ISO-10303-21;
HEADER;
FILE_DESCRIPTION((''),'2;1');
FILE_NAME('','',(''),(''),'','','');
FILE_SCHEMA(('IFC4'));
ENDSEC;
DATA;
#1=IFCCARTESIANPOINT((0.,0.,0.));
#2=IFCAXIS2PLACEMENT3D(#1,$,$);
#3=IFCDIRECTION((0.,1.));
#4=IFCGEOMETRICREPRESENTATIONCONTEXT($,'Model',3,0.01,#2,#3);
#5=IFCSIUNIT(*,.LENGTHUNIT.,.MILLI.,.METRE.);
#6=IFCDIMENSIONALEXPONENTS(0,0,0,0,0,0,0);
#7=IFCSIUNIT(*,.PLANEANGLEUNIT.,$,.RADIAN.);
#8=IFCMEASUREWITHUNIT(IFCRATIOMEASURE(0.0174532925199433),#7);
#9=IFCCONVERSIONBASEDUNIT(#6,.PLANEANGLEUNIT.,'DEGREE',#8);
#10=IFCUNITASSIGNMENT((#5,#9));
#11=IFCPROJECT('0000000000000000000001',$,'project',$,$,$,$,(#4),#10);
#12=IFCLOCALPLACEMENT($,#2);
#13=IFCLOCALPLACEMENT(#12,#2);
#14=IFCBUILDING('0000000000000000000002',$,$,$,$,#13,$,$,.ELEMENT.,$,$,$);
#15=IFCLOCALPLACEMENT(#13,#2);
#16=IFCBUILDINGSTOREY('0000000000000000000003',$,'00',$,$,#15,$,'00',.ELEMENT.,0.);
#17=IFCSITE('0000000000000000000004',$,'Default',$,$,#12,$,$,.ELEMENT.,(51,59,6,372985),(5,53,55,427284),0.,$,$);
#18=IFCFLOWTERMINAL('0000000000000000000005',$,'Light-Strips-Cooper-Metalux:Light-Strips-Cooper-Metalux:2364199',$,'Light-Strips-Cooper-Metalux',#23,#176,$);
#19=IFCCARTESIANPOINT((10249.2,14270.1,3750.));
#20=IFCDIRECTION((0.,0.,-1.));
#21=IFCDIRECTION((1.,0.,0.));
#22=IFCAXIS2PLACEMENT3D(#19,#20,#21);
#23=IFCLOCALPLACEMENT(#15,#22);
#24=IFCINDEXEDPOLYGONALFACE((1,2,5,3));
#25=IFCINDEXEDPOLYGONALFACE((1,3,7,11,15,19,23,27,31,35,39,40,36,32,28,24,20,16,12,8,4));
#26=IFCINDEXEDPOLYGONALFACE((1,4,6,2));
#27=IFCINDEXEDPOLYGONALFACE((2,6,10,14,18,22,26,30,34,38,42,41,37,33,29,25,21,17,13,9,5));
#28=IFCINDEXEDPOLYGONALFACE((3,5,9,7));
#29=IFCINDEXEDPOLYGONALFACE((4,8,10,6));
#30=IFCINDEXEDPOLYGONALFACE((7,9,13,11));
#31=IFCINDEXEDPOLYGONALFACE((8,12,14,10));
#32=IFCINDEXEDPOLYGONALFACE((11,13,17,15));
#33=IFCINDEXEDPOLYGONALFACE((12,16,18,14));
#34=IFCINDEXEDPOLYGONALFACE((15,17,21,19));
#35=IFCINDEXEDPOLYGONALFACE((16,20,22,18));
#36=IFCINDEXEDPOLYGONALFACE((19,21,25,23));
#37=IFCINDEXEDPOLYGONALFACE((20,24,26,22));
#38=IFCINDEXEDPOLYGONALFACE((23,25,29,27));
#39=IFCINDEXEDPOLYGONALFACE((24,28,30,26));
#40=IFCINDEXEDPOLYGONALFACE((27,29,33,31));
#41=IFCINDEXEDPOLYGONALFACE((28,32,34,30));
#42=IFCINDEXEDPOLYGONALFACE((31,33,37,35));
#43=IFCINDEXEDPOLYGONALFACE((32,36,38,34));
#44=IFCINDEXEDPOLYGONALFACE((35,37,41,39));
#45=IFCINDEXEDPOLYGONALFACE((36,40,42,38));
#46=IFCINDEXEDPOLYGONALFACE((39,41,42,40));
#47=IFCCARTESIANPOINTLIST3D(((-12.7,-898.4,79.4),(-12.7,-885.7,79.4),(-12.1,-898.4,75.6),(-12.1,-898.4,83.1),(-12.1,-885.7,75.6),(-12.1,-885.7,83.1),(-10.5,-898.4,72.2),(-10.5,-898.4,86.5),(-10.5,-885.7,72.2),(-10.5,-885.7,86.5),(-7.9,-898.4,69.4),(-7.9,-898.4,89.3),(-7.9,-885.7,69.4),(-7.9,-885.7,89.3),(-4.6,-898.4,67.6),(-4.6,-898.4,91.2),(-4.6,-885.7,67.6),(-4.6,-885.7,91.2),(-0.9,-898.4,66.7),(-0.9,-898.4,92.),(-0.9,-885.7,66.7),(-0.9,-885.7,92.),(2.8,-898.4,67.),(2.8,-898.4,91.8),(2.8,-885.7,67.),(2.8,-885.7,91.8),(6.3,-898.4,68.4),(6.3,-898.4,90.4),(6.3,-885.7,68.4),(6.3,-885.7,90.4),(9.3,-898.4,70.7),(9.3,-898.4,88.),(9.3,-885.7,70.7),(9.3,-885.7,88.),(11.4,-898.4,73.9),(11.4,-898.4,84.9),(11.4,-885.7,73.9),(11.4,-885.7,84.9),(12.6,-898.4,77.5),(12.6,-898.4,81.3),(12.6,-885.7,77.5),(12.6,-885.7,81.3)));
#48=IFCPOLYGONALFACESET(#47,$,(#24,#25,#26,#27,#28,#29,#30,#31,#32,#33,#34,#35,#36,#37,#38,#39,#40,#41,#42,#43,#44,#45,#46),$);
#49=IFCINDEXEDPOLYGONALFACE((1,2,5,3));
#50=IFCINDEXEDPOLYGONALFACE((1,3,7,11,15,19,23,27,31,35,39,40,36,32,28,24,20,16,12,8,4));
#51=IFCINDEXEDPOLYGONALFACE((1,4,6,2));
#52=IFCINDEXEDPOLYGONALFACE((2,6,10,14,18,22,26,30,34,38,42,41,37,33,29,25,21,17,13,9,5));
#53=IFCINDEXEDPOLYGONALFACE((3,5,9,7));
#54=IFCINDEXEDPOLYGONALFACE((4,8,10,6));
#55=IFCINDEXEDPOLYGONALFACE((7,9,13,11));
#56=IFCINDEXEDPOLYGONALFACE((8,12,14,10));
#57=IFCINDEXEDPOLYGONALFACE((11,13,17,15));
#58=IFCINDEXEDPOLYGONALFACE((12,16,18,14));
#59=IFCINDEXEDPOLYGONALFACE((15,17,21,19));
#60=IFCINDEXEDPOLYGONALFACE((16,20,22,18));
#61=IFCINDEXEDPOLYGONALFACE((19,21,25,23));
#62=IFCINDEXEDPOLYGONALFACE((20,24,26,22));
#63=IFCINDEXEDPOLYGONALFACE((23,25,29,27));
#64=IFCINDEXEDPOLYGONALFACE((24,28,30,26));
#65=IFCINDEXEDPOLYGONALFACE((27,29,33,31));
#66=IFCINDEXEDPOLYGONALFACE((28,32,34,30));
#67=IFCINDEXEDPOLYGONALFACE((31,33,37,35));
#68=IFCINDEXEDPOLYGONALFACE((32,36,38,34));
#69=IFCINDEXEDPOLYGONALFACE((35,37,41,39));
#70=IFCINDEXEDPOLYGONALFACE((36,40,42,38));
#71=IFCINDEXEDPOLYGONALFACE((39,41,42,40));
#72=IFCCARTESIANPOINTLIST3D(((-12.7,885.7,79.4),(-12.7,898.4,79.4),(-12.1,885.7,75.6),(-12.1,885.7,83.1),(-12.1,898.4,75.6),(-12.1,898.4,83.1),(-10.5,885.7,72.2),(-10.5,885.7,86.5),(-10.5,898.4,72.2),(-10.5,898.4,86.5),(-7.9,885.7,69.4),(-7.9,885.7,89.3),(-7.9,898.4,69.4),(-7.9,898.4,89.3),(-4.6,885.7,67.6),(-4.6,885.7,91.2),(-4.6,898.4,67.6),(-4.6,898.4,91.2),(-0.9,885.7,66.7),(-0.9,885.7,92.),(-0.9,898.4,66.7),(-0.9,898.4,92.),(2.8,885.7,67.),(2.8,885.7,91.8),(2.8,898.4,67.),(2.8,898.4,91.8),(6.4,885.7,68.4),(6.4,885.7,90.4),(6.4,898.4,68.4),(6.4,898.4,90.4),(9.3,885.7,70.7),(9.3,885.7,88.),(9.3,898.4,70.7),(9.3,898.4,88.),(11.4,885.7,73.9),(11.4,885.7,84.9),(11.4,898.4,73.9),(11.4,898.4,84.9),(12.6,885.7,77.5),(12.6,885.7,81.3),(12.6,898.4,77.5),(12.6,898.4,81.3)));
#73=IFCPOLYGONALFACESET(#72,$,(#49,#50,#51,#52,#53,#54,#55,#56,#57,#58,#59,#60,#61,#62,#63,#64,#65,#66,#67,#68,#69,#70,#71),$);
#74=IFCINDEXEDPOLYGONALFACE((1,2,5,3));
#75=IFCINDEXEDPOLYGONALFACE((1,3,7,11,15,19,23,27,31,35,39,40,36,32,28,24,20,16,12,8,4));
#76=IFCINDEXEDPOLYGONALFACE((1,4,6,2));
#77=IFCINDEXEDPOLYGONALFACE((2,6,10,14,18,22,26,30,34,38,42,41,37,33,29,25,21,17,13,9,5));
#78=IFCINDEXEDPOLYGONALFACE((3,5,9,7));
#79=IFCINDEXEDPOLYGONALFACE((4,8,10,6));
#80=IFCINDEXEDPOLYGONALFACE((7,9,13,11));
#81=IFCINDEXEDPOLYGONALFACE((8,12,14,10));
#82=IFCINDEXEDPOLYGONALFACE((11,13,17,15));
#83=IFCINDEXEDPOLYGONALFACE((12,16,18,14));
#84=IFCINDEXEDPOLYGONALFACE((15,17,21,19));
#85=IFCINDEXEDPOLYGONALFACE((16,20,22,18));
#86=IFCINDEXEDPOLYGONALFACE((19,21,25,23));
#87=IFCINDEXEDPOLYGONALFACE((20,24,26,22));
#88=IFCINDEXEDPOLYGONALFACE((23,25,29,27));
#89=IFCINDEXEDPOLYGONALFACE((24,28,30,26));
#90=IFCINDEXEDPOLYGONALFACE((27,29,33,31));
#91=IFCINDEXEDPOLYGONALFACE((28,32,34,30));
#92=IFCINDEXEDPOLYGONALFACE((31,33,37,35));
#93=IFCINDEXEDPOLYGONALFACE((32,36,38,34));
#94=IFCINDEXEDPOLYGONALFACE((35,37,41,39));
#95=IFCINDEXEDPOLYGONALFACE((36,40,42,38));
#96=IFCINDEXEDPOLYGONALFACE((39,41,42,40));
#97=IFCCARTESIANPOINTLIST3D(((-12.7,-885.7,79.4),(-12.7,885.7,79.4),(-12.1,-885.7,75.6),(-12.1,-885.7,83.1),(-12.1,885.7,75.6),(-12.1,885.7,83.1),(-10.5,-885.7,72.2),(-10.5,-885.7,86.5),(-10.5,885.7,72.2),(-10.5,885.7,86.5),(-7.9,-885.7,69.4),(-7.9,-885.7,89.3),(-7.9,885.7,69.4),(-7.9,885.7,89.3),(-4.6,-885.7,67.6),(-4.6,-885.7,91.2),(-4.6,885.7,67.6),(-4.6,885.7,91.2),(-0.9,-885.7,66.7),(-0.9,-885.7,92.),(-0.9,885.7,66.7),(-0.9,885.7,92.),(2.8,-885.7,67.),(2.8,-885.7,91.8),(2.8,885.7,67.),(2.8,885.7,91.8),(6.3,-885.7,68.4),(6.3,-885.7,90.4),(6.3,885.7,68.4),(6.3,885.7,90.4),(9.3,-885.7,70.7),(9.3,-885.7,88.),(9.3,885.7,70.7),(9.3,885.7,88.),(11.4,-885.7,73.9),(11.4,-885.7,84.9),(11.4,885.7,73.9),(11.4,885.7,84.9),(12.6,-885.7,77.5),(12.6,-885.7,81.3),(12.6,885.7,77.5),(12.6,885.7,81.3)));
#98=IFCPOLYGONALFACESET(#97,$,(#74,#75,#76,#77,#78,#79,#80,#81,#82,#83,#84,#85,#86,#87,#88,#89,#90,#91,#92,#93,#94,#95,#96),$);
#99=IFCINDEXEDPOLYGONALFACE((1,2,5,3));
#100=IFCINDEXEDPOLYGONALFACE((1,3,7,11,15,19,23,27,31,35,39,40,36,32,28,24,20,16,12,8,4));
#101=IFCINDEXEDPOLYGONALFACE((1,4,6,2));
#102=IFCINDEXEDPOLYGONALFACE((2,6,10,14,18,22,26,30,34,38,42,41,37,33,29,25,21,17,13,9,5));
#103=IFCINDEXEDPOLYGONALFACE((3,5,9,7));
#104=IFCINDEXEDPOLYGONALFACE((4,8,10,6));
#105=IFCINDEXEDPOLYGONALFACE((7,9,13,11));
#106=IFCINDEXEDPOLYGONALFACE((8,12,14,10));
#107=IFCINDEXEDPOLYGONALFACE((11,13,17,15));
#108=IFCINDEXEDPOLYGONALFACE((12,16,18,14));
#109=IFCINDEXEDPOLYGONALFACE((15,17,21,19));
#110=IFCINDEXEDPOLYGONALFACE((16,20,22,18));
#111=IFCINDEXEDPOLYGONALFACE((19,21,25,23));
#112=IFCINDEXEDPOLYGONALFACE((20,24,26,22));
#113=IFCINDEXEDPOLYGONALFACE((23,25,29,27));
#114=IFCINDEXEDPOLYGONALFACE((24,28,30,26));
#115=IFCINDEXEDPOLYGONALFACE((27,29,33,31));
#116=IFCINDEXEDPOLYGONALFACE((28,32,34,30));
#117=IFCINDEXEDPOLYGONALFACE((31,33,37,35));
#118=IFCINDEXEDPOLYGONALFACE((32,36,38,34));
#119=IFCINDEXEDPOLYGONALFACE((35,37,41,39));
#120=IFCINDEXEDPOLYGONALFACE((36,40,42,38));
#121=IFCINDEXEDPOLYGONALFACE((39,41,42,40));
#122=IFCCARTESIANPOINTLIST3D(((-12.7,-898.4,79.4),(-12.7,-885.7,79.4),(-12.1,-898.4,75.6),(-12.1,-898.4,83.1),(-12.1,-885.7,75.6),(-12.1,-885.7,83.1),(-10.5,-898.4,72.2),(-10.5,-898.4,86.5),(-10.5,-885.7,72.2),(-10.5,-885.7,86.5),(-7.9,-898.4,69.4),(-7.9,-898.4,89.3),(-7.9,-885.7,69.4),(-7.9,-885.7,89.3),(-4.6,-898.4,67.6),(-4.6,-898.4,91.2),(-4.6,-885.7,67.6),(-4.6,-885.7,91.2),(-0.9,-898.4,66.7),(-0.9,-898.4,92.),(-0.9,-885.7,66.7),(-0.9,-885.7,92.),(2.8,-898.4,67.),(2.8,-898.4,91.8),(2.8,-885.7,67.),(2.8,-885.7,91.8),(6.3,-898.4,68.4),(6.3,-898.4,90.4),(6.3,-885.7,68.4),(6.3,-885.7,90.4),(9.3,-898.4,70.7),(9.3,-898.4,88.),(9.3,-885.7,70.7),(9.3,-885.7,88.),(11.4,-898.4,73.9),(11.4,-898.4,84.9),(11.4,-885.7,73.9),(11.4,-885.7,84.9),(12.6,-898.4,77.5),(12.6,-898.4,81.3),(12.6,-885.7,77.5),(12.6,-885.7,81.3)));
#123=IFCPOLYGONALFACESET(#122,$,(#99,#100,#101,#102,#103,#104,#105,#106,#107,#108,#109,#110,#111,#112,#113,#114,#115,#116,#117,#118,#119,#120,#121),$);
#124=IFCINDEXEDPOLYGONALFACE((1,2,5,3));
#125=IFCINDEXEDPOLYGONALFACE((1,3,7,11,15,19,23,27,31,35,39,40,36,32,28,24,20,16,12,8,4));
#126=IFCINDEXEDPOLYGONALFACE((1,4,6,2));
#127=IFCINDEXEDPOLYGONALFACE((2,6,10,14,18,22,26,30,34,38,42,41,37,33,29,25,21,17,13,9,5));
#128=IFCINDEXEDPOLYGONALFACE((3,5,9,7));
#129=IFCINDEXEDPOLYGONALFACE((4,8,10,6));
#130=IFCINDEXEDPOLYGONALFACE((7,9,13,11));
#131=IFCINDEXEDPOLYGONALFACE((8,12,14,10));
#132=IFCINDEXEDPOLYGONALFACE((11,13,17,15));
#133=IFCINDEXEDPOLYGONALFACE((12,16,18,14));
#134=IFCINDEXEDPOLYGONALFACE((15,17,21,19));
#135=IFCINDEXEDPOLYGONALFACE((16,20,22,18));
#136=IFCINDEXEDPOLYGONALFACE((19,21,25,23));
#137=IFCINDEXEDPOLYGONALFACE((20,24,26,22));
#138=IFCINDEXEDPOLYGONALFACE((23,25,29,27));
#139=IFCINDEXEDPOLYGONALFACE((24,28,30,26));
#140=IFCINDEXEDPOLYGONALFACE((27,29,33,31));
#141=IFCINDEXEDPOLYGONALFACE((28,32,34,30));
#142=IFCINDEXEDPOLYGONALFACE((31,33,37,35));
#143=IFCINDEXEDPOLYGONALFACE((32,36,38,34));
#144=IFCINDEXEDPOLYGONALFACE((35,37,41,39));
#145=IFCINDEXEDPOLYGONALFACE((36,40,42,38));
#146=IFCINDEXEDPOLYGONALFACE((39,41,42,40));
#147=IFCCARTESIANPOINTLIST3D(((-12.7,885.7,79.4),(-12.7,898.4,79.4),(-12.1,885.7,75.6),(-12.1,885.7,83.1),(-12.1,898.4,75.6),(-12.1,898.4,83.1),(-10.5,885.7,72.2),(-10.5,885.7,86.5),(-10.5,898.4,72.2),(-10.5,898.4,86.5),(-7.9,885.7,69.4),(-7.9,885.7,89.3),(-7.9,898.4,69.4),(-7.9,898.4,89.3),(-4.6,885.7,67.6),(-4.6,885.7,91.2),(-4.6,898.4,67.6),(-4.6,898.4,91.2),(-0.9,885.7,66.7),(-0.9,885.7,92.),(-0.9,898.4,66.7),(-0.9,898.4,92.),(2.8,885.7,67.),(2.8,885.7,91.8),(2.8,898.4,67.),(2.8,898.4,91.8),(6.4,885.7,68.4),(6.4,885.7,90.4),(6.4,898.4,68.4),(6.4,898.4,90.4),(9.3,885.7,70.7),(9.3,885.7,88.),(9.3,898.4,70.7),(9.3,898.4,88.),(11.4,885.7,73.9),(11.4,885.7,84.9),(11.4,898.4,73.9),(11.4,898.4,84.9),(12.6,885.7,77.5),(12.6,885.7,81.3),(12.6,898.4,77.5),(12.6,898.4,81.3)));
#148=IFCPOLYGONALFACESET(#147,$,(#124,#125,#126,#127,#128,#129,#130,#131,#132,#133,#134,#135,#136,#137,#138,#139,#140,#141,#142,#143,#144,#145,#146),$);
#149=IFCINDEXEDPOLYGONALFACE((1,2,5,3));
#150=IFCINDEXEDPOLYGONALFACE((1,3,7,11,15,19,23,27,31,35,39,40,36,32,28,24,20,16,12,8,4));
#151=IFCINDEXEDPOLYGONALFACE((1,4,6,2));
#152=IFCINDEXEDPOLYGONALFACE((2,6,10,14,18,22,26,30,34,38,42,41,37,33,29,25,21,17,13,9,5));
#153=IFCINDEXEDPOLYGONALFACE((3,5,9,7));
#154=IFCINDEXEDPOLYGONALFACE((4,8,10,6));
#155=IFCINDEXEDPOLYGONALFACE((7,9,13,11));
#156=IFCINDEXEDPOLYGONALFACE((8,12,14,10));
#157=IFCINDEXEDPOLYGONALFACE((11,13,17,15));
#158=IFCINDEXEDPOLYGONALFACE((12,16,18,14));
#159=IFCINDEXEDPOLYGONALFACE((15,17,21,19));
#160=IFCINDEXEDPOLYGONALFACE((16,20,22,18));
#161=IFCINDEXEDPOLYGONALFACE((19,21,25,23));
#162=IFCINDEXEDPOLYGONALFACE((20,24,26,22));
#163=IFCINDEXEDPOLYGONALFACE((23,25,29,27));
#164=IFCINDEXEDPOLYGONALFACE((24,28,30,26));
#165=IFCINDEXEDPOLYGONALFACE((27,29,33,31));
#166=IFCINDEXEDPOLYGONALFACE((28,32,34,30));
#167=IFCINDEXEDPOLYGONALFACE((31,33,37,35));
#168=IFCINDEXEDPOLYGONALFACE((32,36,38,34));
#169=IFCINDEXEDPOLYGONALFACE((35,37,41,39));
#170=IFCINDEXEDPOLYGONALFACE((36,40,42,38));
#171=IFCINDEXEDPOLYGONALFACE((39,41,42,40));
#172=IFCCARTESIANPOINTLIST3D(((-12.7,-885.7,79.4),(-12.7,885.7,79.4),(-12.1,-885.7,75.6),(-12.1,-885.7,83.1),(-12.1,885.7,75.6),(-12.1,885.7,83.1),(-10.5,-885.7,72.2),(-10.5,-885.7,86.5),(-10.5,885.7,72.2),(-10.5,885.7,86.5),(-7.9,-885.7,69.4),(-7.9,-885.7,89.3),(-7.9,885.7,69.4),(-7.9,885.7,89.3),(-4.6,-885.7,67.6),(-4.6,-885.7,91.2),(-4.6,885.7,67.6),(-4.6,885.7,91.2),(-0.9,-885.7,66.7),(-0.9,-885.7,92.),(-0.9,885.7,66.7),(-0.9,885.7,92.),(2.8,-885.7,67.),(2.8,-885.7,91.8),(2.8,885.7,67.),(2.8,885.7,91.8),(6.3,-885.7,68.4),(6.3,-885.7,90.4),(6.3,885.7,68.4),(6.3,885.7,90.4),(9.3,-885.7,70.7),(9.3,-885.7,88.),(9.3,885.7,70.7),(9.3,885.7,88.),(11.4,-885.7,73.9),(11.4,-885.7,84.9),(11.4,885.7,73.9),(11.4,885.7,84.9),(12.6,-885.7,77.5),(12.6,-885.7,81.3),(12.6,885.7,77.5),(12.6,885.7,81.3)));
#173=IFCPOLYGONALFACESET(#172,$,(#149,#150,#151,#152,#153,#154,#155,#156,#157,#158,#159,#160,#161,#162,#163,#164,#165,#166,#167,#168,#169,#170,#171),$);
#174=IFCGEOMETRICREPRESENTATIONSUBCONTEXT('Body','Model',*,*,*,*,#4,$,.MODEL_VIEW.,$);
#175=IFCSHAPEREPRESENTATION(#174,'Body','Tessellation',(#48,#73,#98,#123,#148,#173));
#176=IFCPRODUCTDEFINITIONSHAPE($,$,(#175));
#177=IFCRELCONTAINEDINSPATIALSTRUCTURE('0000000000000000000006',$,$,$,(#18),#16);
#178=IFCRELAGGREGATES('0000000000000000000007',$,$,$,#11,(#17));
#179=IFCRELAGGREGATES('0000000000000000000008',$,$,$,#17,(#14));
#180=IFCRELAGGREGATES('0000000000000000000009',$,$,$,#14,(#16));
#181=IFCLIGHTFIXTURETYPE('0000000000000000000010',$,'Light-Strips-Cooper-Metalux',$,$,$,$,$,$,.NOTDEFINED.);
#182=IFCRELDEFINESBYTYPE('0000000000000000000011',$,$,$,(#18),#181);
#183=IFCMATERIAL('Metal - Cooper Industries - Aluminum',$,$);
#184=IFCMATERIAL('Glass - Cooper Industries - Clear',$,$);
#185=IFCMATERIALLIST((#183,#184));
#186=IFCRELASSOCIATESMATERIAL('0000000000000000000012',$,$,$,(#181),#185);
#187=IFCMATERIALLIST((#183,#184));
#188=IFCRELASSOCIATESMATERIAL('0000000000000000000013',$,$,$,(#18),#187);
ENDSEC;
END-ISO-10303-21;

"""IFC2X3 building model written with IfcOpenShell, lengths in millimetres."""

from ifc_helpers import new_model, entity, si_unit, converted_unit, direction, frame, frame_2d, origin, place, context, subcontext, project, spatial, circle, extrude, source, transform, mapped, material, material_list, type_object, type_shapes, element, save


model = new_model("IFC2X3")

# Units and contexts
model_context = context("Model", 3, precision=0.01, world=origin(), true_north=direction((0.0, 1.0)))
body_context = subcontext(model_context, "Body", "Model", "MODEL_VIEW")
ifc_project = project(units=[si_unit("LENGTHUNIT", "METRE", prefix="MILLI"), converted_unit("PLANEANGLEUNIT", "DEGREE", entity("IfcRatioMeasure", 0.0174532925199433), si_unit("PLANEANGLEUNIT", "RADIAN"), dimensions=[0, 0, 0, 0, 0, 0, 0])], contexts=[model_context])

# Site, building, storey
site_placement = place(None, origin())
site = spatial("IfcSite", under=ifc_project, at=site_placement, Name="Default", CompositionType="ELEMENT", RefLatitude=(51, 59, 6, 372985), RefLongitude=(5, 53, 55, 427284), RefElevation=0.0)
building_placement = place(site_placement, origin())
building = spatial("IfcBuilding", under=site, at=building_placement, CompositionType="ELEMENT")
storey_placement = place(building_placement, origin())
storey = spatial("IfcBuildingStorey", under=building, at=storey_placement, Name="00", LongName="00", CompositionType="ELEMENT", Elevation=0.0)

# Flow terminal
ifc_material_1 = material(Name="Metal - Cooper Industries - Aluminum")
ifc_material_2 = material(Name="Glass - Cooper Industries - Clear")
ifc_material_list_1 = material_list([ifc_material_1, ifc_material_2])
ifc_material_list_2 = material_list([ifc_material_1, ifc_material_2])
light_fixture_type_1 = type_object("IfcLightFixtureType", Name="Light-Strips-Cooper-Metalux", PredefinedType="NOTDEFINED", material=ifc_material_list_2)
shared_shape_1 = source(origin(), body_context, "Body", "SweptSolid", [
    extrude(circle(Radius=12.7, at=frame_2d((0.0, 0.0), x_axis=(1.0, 0.0))), frame((0.0, -898.4, 79.4), z_axis=(0.0, 1.0, 0.0), x_axis=(-1.0, 0.0, 0.0)), (0.0, 0.0, 1.0), 12.7),
    extrude(circle(Radius=12.7, at=frame_2d((0.0, 0.0), x_axis=(1.0, 0.0))), frame((0.0, 885.7, 79.4), z_axis=(0.0, 1.0, 0.0), x_axis=(-1.0, 0.0, 0.0)), (0.0, 0.0, 1.0), 12.7),
    extrude(circle(Radius=12.7, at=frame_2d((0.0, 0.0), x_axis=(1.0, 0.0))), frame((0.0, -885.7, 79.4), z_axis=(0.0, 1.0, 0.0), x_axis=(-1.0, 0.0, 0.0)), (0.0, 0.0, 1.0), 1771.4),
    extrude(circle(Radius=12.7, at=frame_2d((0.0, 0.0), x_axis=(1.0, 0.0))), frame((0.0, -898.4, 79.4), z_axis=(0.0, 1.0, 0.0), x_axis=(-1.0, 0.0, 0.0)), (0.0, 0.0, 1.0), 12.7),
    extrude(circle(Radius=12.7, at=frame_2d((0.0, 0.0), x_axis=(1.0, 0.0))), frame((0.0, 885.7, 79.4), z_axis=(0.0, 1.0, 0.0), x_axis=(-1.0, 0.0, 0.0)), (0.0, 0.0, 1.0), 12.7),
    extrude(circle(Radius=12.7, at=frame_2d((0.0, 0.0), x_axis=(1.0, 0.0))), frame((0.0, -885.7, 79.4), z_axis=(0.0, 1.0, 0.0), x_axis=(-1.0, 0.0, 0.0)), (0.0, 0.0, 1.0), 1771.4),
])
type_shapes(light_fixture_type_1, [shared_shape_1])
flow_terminal_1_placement = place(storey_placement, frame((10249.2, 14270.1, 3750.0), z_axis=(0.0, 0.0, -1.0), x_axis=(1.0, 0.0, 0.0)))
element("IfcFlowTerminal", 1, at=flow_terminal_1_placement, inside=storey, type_object=light_fixture_type_1, material=ifc_material_list_1, Name="Light-Strips-Cooper-Metalux:Light-Strips-Cooper-Metalux:2364199", ObjectType="Light-Strips-Cooper-Metalux", context=body_context, shape_type="MappedRepresentation", body=[
    mapped(shared_shape_1, transform((0.0, 0.0, 0.0), scale=1.0)),
])

save(model, "model.ifc")
